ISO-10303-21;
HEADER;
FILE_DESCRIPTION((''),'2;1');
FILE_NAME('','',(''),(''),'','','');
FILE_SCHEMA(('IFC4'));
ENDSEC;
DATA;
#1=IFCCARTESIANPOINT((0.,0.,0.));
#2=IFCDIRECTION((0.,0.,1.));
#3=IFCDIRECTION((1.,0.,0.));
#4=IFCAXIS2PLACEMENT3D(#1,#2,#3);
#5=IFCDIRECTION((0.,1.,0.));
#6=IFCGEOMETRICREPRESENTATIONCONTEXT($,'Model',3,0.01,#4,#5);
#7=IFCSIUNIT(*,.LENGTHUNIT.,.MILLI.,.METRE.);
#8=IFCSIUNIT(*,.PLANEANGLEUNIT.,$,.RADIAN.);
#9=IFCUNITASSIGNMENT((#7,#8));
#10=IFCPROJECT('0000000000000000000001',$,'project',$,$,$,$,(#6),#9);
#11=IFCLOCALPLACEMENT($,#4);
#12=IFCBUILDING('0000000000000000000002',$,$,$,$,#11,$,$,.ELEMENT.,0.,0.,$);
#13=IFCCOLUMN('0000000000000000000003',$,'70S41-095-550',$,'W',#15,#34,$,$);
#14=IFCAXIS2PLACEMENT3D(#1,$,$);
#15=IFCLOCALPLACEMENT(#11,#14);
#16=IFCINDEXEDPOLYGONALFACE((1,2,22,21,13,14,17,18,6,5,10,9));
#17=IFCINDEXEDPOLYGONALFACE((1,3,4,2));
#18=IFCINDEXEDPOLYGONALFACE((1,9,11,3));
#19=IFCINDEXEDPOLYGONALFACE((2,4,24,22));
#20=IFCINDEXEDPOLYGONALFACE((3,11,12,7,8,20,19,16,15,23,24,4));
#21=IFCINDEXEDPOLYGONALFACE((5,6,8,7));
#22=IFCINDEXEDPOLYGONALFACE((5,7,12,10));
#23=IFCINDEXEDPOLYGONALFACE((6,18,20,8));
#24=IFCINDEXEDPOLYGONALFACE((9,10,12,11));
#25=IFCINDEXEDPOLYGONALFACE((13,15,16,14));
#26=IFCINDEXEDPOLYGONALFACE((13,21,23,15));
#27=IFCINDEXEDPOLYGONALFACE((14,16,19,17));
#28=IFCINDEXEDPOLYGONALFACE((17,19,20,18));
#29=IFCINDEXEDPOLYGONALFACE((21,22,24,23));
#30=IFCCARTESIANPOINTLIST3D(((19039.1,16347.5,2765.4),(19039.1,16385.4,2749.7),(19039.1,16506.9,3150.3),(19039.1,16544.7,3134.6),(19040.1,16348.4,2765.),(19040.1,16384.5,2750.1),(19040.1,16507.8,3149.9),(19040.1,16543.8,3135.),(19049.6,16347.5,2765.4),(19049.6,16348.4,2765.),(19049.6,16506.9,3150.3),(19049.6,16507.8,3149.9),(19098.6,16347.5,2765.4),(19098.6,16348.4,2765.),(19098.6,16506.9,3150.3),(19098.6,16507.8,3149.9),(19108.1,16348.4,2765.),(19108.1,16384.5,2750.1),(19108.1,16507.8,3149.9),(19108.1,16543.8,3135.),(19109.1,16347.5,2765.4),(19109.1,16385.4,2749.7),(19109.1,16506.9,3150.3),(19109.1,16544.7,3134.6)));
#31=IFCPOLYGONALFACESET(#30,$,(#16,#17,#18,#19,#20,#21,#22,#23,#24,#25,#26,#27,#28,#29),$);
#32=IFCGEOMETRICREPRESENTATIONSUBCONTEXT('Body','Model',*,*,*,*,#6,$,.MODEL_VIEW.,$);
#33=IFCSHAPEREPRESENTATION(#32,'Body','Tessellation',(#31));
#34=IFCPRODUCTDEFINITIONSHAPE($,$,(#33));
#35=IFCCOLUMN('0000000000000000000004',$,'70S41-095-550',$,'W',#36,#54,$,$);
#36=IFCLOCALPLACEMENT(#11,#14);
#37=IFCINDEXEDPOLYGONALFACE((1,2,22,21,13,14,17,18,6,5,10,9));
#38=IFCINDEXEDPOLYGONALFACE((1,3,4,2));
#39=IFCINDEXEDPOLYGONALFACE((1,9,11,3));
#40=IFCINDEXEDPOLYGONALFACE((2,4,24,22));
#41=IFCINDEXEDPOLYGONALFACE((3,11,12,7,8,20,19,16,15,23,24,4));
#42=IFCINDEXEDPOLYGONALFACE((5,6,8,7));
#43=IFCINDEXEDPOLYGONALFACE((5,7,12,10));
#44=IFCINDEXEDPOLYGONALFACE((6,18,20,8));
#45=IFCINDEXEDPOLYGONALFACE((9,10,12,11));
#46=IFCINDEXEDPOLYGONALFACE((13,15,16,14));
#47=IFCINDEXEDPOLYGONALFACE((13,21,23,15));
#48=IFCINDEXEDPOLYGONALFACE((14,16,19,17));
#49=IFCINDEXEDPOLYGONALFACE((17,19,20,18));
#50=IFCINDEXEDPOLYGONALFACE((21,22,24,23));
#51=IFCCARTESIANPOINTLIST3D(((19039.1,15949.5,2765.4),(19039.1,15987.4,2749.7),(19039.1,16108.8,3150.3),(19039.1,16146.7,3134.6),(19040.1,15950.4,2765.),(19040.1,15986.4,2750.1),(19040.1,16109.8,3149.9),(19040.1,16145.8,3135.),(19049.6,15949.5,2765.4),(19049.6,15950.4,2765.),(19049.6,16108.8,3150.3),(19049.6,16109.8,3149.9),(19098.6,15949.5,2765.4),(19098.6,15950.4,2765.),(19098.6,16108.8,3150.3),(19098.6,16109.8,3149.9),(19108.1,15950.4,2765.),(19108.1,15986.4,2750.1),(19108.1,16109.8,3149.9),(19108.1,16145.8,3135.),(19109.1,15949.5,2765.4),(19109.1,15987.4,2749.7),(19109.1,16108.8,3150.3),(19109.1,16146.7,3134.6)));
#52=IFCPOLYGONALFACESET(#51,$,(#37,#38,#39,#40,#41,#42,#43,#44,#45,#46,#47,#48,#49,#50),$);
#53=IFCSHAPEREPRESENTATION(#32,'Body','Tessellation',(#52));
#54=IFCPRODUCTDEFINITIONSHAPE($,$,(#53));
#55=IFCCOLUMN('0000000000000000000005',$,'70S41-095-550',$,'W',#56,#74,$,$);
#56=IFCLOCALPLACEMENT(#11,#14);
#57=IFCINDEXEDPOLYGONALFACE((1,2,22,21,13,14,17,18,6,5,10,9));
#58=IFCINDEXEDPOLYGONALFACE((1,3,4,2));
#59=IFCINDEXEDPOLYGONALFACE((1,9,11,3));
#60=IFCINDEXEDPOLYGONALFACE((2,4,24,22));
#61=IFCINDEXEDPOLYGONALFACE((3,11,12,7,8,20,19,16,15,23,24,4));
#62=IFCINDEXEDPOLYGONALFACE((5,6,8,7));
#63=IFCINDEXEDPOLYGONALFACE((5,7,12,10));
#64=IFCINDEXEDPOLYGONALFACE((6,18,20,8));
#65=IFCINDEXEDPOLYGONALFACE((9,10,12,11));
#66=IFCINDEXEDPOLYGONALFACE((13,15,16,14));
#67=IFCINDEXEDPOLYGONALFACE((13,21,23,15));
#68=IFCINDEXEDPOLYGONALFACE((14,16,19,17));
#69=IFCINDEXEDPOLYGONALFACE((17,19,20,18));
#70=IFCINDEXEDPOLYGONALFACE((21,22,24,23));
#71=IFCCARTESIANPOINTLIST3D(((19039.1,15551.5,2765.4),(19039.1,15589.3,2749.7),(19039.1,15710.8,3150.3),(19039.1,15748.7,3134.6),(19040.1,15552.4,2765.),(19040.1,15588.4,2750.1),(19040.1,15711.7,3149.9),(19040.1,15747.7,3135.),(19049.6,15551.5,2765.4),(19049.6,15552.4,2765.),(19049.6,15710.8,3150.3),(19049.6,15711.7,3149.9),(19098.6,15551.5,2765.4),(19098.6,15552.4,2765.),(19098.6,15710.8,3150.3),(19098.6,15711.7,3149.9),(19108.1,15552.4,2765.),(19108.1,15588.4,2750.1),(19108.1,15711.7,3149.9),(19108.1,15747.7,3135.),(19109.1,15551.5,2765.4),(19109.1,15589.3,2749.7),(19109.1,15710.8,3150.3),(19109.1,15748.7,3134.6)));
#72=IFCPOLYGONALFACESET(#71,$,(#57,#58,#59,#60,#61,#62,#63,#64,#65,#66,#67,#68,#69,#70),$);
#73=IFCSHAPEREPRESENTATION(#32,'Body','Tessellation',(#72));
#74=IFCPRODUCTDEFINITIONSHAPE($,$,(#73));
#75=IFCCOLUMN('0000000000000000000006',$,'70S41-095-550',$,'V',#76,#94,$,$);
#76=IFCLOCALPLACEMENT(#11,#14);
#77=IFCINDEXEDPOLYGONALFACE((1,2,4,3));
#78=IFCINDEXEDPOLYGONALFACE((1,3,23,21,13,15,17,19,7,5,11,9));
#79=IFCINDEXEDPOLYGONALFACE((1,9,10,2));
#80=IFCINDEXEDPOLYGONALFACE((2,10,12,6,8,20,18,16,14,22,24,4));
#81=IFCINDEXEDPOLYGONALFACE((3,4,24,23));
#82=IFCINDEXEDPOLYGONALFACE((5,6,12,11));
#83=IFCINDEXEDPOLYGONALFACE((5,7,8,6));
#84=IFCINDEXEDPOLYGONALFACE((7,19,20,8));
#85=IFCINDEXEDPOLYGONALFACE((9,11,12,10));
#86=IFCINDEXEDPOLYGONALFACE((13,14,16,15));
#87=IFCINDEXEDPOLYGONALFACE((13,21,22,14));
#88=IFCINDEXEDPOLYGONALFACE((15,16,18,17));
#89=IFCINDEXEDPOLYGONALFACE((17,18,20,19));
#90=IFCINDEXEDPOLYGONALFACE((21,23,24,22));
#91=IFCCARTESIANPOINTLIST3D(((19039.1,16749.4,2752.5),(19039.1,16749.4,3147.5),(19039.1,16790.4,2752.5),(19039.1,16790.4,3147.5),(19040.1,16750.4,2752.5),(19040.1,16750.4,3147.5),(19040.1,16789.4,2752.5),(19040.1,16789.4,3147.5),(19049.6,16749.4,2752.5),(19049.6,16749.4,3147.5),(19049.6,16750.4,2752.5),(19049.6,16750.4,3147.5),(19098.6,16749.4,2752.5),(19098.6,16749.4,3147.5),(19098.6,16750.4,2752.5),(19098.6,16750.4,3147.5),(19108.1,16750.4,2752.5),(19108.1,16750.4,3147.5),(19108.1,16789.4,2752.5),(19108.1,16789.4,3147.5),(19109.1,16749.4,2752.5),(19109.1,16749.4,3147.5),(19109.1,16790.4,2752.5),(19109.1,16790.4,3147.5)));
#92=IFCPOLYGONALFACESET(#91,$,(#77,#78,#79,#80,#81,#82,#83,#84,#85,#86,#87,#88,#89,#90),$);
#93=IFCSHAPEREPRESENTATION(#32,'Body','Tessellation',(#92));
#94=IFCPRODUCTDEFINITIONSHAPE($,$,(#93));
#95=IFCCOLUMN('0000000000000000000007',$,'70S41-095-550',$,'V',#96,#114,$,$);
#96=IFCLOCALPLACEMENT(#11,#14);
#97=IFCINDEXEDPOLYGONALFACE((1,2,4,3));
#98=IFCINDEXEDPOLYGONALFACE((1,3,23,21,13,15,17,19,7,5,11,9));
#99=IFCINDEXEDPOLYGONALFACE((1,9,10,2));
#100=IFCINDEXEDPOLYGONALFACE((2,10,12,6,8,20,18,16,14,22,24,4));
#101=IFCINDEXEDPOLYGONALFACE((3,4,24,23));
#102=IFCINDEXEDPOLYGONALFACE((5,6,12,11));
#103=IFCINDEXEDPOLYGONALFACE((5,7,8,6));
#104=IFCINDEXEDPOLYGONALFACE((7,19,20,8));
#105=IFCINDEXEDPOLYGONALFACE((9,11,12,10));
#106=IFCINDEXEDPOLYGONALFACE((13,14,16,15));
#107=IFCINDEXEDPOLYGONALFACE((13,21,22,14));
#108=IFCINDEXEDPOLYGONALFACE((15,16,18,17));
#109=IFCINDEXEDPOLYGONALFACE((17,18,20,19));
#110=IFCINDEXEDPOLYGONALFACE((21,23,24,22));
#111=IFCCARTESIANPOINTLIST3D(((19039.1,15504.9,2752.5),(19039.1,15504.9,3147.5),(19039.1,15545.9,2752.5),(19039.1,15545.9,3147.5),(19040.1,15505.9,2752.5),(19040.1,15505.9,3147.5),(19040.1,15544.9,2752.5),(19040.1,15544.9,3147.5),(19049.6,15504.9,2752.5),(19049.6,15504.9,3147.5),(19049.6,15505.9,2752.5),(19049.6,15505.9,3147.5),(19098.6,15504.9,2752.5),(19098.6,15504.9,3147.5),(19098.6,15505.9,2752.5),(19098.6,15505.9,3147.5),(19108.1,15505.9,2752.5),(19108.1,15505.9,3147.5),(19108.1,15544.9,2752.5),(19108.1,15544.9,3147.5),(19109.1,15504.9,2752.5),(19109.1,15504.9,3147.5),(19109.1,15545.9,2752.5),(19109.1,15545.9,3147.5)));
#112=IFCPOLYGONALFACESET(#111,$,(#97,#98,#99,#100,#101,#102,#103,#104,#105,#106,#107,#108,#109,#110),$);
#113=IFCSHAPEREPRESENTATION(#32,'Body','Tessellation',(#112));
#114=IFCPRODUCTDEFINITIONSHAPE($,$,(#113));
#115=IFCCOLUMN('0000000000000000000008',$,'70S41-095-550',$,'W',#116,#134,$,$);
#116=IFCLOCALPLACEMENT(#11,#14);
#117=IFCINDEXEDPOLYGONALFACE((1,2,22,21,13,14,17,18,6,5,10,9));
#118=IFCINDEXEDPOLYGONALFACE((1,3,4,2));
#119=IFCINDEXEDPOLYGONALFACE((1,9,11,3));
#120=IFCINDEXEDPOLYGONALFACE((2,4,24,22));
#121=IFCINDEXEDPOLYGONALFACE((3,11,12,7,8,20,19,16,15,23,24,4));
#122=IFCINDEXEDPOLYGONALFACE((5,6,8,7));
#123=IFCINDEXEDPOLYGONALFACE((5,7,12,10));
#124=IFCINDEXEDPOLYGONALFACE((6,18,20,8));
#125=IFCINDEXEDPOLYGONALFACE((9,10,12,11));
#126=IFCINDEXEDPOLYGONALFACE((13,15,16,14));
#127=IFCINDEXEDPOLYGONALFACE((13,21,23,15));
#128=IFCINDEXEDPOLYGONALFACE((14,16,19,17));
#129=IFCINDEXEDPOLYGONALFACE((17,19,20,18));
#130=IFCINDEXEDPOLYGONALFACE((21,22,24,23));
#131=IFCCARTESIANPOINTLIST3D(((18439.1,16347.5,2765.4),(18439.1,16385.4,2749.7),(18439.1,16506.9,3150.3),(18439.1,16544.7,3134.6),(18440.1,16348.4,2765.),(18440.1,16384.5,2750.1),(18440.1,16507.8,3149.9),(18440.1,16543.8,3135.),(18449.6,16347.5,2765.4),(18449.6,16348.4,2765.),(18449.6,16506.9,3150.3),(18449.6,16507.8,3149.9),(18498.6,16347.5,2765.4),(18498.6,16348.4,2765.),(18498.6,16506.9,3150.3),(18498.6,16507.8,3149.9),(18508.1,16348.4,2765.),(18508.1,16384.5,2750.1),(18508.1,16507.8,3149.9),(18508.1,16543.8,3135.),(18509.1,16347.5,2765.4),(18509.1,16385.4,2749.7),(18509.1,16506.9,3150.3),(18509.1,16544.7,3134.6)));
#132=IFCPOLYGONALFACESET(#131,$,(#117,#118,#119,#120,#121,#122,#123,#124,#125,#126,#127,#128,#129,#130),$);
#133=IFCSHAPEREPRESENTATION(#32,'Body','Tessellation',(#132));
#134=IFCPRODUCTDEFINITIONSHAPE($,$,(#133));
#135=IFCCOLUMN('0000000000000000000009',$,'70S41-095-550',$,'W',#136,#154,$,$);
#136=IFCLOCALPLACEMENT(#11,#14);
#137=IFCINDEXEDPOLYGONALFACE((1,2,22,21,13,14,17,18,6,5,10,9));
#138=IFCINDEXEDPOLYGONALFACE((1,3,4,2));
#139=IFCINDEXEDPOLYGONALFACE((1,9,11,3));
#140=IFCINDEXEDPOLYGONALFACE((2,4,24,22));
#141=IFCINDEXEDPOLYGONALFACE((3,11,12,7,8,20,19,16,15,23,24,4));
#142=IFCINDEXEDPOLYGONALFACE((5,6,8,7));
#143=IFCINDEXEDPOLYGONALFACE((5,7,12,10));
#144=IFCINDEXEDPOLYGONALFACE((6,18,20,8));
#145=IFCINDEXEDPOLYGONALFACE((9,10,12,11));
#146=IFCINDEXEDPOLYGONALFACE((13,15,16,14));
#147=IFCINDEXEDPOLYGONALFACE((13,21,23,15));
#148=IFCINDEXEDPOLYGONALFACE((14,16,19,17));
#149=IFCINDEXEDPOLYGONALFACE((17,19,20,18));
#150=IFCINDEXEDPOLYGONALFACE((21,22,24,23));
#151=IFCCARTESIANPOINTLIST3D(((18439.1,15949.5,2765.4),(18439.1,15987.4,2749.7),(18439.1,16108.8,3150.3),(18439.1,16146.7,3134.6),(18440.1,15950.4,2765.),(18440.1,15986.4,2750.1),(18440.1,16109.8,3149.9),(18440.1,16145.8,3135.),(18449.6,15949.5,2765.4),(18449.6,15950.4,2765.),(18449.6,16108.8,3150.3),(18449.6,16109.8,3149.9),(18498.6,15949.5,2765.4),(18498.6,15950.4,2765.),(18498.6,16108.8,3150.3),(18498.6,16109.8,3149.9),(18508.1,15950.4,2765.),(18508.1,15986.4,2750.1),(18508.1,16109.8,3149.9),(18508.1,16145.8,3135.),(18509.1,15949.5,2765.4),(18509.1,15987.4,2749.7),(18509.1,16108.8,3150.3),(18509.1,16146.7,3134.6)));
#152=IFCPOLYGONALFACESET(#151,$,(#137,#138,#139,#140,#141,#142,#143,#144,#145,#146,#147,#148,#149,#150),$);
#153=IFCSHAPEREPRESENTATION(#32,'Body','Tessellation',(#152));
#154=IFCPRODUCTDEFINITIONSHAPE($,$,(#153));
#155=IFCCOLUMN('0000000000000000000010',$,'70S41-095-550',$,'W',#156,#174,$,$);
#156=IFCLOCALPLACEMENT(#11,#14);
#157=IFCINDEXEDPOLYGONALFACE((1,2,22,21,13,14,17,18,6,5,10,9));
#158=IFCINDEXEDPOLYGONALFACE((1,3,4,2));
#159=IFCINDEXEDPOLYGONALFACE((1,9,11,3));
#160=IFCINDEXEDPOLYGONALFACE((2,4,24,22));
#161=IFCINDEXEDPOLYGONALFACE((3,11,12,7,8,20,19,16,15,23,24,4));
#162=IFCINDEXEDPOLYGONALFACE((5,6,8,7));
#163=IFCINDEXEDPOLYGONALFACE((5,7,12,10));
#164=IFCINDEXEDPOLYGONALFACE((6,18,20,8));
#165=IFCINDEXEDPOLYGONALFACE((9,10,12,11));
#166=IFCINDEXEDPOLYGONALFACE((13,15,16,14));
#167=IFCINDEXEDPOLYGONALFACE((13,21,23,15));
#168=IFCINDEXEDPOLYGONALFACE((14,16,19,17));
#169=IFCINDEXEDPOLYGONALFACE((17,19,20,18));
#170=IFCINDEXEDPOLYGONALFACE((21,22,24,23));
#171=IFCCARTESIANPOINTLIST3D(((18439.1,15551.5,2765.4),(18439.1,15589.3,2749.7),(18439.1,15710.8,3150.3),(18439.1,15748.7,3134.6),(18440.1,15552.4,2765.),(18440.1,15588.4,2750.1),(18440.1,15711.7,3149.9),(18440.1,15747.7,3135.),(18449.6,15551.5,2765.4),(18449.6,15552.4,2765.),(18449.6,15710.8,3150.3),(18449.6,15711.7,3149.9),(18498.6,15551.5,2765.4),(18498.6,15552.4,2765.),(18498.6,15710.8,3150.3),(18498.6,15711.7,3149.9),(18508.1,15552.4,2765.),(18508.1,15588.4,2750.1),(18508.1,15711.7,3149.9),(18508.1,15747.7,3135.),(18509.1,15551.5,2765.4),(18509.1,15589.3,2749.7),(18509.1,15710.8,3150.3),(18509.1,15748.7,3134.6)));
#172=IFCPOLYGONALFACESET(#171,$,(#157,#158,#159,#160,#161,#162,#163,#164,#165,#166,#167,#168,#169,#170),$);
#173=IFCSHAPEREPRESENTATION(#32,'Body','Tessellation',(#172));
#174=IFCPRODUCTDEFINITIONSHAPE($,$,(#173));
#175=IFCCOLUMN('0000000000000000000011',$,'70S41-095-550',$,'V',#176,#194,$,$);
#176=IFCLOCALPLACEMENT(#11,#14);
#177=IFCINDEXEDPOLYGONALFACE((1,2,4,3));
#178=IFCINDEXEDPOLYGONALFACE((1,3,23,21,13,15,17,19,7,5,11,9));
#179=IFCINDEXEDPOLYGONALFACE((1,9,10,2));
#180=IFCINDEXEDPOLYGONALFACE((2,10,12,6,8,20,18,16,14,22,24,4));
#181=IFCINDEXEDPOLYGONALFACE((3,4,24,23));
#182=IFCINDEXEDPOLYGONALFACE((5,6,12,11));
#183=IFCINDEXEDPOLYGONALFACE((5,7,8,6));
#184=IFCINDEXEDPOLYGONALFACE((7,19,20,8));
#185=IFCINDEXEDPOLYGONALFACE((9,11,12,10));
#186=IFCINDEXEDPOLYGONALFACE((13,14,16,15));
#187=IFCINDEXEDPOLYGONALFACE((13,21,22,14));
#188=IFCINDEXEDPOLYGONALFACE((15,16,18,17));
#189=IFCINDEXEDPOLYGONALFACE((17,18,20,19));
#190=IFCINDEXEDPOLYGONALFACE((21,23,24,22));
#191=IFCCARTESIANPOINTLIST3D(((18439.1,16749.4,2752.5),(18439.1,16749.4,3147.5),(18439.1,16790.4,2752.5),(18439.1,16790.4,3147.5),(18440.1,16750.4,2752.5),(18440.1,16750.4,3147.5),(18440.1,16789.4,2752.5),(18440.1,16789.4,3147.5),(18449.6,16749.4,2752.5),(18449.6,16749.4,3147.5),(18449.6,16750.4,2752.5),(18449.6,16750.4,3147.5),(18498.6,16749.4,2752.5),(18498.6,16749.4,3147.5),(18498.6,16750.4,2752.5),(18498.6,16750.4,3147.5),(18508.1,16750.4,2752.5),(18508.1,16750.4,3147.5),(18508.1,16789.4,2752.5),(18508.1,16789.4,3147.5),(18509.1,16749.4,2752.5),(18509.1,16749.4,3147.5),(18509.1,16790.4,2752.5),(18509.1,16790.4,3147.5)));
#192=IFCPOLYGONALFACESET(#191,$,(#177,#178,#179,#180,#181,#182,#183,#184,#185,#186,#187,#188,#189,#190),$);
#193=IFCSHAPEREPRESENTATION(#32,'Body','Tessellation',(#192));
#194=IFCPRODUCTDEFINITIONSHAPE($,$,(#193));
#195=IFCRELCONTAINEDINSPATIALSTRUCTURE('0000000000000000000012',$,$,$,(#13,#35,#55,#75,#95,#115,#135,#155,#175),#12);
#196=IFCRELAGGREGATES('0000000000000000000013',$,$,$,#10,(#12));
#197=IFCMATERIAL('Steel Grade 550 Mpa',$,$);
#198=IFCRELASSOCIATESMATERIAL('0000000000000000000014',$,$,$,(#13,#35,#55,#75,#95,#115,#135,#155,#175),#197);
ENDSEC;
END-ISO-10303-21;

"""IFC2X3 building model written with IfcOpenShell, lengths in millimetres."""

from ifc_helpers import new_model, si_unit, direction, frame, origin, origin_with_axes, origin_2d_with_axis, place, context, subcontext, project, spatial, c_section, extrude, source, transform, mapped, material, element, save


model = new_model("IFC2X3")

# Units and contexts
model_context = context("Model", 3, precision=0.01, world=origin_with_axes(), true_north=direction((0.0, 1.0, 0.0)))
body_context = subcontext(model_context, "Body", "Model", "MODEL_VIEW")
ifc_project = project(units=[si_unit("LENGTHUNIT", "METRE", prefix="MILLI"), si_unit("PLANEANGLEUNIT", "RADIAN")], contexts=[model_context])

# Building
building_placement = place(None, origin_with_axes())
building = spatial("IfcBuilding", under=ifc_project, at=building_placement, CompositionType="ELEMENT", ElevationOfRefHeight=0.0, ElevationOfTerrain=0.0)

# Columns
ifc_material = material(Name="Steel Grade 550 Mpa")
shared_shape_1 = source(origin(), body_context, "Body", "SweptSolid", [
    extrude(c_section(Depth=70.0, Width=41.0, WallThickness=1.0, Girth=10.5, at=origin_2d_with_axis()), origin_with_axes(), (0.0, 0.0, 1.0), 416.6),
])
column_1_placement = place(None, frame((19074.1, 16366.5, 2757.6), z_axis=(0.0, 0.382523, 0.923946), x_axis=(0.0, -0.923946, 0.382523)))
element("IfcColumn", 1, at=column_1_placement, inside=building, material=ifc_material, Name="70S41-095-550", ObjectType="W", context=body_context, shape_type="MappedRepresentation", body=[
    mapped(shared_shape_1, transform((0.0, 0.0, 0.0), scale=1.0)),
])
shared_shape_2 = source(origin(), body_context, "Body", "SweptSolid", [
    extrude(c_section(Depth=70.0, Width=41.0, WallThickness=1.0, Girth=10.5, at=origin_2d_with_axis()), origin_with_axes(), (0.0, 0.0, 1.0), 416.6),
])
column_2_placement = place(None, frame((19074.1, 15968.4, 2757.6), z_axis=(0.0, 0.382523, 0.923946), x_axis=(0.0, -0.923946, 0.382523)))
element("IfcColumn", 2, at=column_2_placement, inside=building, material=ifc_material, Name="70S41-095-550", ObjectType="W", context=body_context, shape_type="MappedRepresentation", body=[
    mapped(shared_shape_2, transform((0.0, 0.0, 0.0), scale=1.0)),
])
shared_shape_3 = source(origin(), body_context, "Body", "SweptSolid", [
    extrude(c_section(Depth=70.0, Width=41.0, WallThickness=1.0, Girth=10.5, at=origin_2d_with_axis()), origin_with_axes(), (0.0, 0.0, 1.0), 416.6),
])
column_3_placement = place(None, frame((19074.1, 15570.4, 2757.6), z_axis=(0.0, 0.382523, 0.923946), x_axis=(0.0, -0.923946, 0.382523)))
element("IfcColumn", 3, at=column_3_placement, inside=building, material=ifc_material, Name="70S41-095-550", ObjectType="W", context=body_context, shape_type="MappedRepresentation", body=[
    mapped(shared_shape_3, transform((0.0, 0.0, 0.0), scale=1.0)),
])
shared_shape_4 = source(origin(), body_context, "Body", "SweptSolid", [
    extrude(c_section(Depth=70.0, Width=41.0, WallThickness=1.0, Girth=10.5, at=origin_2d_with_axis()), origin_with_axes(), (0.0, 0.0, 1.0), 395.0),
])
column_4_placement = place(None, frame((19074.1, 16769.9, 2752.5), z_axis=(0.0, 0.0, 1.0), x_axis=(0.0, -1.0, 0.0)))
element("IfcColumn", 4, at=column_4_placement, inside=building, material=ifc_material, Name="70S41-095-550", ObjectType="V", context=body_context, shape_type="MappedRepresentation", body=[
    mapped(shared_shape_4, transform((0.0, 0.0, 0.0), scale=1.0)),
])
shared_shape_5 = source(origin(), body_context, "Body", "SweptSolid", [
    extrude(c_section(Depth=70.0, Width=41.0, WallThickness=1.0, Girth=10.5, at=origin_2d_with_axis()), origin_with_axes(), (0.0, 0.0, 1.0), 395.0),
])
column_5_placement = place(None, frame((19074.1, 15525.4, 2752.5), z_axis=(0.0, 0.0, 1.0), x_axis=(0.0, -1.0, 0.0)))
element("IfcColumn", 5, at=column_5_placement, inside=building, material=ifc_material, Name="70S41-095-550", ObjectType="V", context=body_context, shape_type="MappedRepresentation", body=[
    mapped(shared_shape_5, transform((0.0, 0.0, 0.0), scale=1.0)),
])
shared_shape_6 = source(origin(), body_context, "Body", "SweptSolid", [
    extrude(c_section(Depth=70.0, Width=41.0, WallThickness=1.0, Girth=10.5, at=origin_2d_with_axis()), origin_with_axes(), (0.0, 0.0, 1.0), 416.6),
])
column_6_placement = place(None, frame((18474.1, 16366.5, 2757.6), z_axis=(0.0, 0.382523, 0.923946), x_axis=(0.0, -0.923946, 0.382523)))
element("IfcColumn", 6, at=column_6_placement, inside=building, material=ifc_material, Name="70S41-095-550", ObjectType="W", context=body_context, shape_type="MappedRepresentation", body=[
    mapped(shared_shape_6, transform((0.0, 0.0, 0.0), scale=1.0)),
])
shared_shape_7 = source(origin(), body_context, "Body", "SweptSolid", [
    extrude(c_section(Depth=70.0, Width=41.0, WallThickness=1.0, Girth=10.5, at=origin_2d_with_axis()), origin_with_axes(), (0.0, 0.0, 1.0), 416.6),
])
column_7_placement = place(None, frame((18474.1, 15968.4, 2757.6), z_axis=(0.0, 0.382523, 0.923946), x_axis=(0.0, -0.923946, 0.382523)))
element("IfcColumn", 7, at=column_7_placement, inside=building, material=ifc_material, Name="70S41-095-550", ObjectType="W", context=body_context, shape_type="MappedRepresentation", body=[
    mapped(shared_shape_7, transform((0.0, 0.0, 0.0), scale=1.0)),
])
shared_shape_8 = source(origin(), body_context, "Body", "SweptSolid", [
    extrude(c_section(Depth=70.0, Width=41.0, WallThickness=1.0, Girth=10.5, at=origin_2d_with_axis()), origin_with_axes(), (0.0, 0.0, 1.0), 416.6),
])
column_8_placement = place(None, frame((18474.1, 15570.4, 2757.6), z_axis=(0.0, 0.382523, 0.923946), x_axis=(0.0, -0.923946, 0.382523)))
element("IfcColumn", 8, at=column_8_placement, inside=building, material=ifc_material, Name="70S41-095-550", ObjectType="W", context=body_context, shape_type="MappedRepresentation", body=[
    mapped(shared_shape_8, transform((0.0, 0.0, 0.0), scale=1.0)),
])
shared_shape_9 = source(origin(), body_context, "Body", "SweptSolid", [
    extrude(c_section(Depth=70.0, Width=41.0, WallThickness=1.0, Girth=10.5, at=origin_2d_with_axis()), origin_with_axes(), (0.0, 0.0, 1.0), 395.0),
])
column_9_placement = place(None, frame((18474.1, 16769.9, 2752.5), z_axis=(0.0, 0.0, 1.0), x_axis=(0.0, -1.0, 0.0)))
element("IfcColumn", 9, at=column_9_placement, inside=building, material=ifc_material, Name="70S41-095-550", ObjectType="V", context=body_context, shape_type="MappedRepresentation", body=[
    mapped(shared_shape_9, transform((0.0, 0.0, 0.0), scale=1.0)),
])

save(model, "model.ifc")
